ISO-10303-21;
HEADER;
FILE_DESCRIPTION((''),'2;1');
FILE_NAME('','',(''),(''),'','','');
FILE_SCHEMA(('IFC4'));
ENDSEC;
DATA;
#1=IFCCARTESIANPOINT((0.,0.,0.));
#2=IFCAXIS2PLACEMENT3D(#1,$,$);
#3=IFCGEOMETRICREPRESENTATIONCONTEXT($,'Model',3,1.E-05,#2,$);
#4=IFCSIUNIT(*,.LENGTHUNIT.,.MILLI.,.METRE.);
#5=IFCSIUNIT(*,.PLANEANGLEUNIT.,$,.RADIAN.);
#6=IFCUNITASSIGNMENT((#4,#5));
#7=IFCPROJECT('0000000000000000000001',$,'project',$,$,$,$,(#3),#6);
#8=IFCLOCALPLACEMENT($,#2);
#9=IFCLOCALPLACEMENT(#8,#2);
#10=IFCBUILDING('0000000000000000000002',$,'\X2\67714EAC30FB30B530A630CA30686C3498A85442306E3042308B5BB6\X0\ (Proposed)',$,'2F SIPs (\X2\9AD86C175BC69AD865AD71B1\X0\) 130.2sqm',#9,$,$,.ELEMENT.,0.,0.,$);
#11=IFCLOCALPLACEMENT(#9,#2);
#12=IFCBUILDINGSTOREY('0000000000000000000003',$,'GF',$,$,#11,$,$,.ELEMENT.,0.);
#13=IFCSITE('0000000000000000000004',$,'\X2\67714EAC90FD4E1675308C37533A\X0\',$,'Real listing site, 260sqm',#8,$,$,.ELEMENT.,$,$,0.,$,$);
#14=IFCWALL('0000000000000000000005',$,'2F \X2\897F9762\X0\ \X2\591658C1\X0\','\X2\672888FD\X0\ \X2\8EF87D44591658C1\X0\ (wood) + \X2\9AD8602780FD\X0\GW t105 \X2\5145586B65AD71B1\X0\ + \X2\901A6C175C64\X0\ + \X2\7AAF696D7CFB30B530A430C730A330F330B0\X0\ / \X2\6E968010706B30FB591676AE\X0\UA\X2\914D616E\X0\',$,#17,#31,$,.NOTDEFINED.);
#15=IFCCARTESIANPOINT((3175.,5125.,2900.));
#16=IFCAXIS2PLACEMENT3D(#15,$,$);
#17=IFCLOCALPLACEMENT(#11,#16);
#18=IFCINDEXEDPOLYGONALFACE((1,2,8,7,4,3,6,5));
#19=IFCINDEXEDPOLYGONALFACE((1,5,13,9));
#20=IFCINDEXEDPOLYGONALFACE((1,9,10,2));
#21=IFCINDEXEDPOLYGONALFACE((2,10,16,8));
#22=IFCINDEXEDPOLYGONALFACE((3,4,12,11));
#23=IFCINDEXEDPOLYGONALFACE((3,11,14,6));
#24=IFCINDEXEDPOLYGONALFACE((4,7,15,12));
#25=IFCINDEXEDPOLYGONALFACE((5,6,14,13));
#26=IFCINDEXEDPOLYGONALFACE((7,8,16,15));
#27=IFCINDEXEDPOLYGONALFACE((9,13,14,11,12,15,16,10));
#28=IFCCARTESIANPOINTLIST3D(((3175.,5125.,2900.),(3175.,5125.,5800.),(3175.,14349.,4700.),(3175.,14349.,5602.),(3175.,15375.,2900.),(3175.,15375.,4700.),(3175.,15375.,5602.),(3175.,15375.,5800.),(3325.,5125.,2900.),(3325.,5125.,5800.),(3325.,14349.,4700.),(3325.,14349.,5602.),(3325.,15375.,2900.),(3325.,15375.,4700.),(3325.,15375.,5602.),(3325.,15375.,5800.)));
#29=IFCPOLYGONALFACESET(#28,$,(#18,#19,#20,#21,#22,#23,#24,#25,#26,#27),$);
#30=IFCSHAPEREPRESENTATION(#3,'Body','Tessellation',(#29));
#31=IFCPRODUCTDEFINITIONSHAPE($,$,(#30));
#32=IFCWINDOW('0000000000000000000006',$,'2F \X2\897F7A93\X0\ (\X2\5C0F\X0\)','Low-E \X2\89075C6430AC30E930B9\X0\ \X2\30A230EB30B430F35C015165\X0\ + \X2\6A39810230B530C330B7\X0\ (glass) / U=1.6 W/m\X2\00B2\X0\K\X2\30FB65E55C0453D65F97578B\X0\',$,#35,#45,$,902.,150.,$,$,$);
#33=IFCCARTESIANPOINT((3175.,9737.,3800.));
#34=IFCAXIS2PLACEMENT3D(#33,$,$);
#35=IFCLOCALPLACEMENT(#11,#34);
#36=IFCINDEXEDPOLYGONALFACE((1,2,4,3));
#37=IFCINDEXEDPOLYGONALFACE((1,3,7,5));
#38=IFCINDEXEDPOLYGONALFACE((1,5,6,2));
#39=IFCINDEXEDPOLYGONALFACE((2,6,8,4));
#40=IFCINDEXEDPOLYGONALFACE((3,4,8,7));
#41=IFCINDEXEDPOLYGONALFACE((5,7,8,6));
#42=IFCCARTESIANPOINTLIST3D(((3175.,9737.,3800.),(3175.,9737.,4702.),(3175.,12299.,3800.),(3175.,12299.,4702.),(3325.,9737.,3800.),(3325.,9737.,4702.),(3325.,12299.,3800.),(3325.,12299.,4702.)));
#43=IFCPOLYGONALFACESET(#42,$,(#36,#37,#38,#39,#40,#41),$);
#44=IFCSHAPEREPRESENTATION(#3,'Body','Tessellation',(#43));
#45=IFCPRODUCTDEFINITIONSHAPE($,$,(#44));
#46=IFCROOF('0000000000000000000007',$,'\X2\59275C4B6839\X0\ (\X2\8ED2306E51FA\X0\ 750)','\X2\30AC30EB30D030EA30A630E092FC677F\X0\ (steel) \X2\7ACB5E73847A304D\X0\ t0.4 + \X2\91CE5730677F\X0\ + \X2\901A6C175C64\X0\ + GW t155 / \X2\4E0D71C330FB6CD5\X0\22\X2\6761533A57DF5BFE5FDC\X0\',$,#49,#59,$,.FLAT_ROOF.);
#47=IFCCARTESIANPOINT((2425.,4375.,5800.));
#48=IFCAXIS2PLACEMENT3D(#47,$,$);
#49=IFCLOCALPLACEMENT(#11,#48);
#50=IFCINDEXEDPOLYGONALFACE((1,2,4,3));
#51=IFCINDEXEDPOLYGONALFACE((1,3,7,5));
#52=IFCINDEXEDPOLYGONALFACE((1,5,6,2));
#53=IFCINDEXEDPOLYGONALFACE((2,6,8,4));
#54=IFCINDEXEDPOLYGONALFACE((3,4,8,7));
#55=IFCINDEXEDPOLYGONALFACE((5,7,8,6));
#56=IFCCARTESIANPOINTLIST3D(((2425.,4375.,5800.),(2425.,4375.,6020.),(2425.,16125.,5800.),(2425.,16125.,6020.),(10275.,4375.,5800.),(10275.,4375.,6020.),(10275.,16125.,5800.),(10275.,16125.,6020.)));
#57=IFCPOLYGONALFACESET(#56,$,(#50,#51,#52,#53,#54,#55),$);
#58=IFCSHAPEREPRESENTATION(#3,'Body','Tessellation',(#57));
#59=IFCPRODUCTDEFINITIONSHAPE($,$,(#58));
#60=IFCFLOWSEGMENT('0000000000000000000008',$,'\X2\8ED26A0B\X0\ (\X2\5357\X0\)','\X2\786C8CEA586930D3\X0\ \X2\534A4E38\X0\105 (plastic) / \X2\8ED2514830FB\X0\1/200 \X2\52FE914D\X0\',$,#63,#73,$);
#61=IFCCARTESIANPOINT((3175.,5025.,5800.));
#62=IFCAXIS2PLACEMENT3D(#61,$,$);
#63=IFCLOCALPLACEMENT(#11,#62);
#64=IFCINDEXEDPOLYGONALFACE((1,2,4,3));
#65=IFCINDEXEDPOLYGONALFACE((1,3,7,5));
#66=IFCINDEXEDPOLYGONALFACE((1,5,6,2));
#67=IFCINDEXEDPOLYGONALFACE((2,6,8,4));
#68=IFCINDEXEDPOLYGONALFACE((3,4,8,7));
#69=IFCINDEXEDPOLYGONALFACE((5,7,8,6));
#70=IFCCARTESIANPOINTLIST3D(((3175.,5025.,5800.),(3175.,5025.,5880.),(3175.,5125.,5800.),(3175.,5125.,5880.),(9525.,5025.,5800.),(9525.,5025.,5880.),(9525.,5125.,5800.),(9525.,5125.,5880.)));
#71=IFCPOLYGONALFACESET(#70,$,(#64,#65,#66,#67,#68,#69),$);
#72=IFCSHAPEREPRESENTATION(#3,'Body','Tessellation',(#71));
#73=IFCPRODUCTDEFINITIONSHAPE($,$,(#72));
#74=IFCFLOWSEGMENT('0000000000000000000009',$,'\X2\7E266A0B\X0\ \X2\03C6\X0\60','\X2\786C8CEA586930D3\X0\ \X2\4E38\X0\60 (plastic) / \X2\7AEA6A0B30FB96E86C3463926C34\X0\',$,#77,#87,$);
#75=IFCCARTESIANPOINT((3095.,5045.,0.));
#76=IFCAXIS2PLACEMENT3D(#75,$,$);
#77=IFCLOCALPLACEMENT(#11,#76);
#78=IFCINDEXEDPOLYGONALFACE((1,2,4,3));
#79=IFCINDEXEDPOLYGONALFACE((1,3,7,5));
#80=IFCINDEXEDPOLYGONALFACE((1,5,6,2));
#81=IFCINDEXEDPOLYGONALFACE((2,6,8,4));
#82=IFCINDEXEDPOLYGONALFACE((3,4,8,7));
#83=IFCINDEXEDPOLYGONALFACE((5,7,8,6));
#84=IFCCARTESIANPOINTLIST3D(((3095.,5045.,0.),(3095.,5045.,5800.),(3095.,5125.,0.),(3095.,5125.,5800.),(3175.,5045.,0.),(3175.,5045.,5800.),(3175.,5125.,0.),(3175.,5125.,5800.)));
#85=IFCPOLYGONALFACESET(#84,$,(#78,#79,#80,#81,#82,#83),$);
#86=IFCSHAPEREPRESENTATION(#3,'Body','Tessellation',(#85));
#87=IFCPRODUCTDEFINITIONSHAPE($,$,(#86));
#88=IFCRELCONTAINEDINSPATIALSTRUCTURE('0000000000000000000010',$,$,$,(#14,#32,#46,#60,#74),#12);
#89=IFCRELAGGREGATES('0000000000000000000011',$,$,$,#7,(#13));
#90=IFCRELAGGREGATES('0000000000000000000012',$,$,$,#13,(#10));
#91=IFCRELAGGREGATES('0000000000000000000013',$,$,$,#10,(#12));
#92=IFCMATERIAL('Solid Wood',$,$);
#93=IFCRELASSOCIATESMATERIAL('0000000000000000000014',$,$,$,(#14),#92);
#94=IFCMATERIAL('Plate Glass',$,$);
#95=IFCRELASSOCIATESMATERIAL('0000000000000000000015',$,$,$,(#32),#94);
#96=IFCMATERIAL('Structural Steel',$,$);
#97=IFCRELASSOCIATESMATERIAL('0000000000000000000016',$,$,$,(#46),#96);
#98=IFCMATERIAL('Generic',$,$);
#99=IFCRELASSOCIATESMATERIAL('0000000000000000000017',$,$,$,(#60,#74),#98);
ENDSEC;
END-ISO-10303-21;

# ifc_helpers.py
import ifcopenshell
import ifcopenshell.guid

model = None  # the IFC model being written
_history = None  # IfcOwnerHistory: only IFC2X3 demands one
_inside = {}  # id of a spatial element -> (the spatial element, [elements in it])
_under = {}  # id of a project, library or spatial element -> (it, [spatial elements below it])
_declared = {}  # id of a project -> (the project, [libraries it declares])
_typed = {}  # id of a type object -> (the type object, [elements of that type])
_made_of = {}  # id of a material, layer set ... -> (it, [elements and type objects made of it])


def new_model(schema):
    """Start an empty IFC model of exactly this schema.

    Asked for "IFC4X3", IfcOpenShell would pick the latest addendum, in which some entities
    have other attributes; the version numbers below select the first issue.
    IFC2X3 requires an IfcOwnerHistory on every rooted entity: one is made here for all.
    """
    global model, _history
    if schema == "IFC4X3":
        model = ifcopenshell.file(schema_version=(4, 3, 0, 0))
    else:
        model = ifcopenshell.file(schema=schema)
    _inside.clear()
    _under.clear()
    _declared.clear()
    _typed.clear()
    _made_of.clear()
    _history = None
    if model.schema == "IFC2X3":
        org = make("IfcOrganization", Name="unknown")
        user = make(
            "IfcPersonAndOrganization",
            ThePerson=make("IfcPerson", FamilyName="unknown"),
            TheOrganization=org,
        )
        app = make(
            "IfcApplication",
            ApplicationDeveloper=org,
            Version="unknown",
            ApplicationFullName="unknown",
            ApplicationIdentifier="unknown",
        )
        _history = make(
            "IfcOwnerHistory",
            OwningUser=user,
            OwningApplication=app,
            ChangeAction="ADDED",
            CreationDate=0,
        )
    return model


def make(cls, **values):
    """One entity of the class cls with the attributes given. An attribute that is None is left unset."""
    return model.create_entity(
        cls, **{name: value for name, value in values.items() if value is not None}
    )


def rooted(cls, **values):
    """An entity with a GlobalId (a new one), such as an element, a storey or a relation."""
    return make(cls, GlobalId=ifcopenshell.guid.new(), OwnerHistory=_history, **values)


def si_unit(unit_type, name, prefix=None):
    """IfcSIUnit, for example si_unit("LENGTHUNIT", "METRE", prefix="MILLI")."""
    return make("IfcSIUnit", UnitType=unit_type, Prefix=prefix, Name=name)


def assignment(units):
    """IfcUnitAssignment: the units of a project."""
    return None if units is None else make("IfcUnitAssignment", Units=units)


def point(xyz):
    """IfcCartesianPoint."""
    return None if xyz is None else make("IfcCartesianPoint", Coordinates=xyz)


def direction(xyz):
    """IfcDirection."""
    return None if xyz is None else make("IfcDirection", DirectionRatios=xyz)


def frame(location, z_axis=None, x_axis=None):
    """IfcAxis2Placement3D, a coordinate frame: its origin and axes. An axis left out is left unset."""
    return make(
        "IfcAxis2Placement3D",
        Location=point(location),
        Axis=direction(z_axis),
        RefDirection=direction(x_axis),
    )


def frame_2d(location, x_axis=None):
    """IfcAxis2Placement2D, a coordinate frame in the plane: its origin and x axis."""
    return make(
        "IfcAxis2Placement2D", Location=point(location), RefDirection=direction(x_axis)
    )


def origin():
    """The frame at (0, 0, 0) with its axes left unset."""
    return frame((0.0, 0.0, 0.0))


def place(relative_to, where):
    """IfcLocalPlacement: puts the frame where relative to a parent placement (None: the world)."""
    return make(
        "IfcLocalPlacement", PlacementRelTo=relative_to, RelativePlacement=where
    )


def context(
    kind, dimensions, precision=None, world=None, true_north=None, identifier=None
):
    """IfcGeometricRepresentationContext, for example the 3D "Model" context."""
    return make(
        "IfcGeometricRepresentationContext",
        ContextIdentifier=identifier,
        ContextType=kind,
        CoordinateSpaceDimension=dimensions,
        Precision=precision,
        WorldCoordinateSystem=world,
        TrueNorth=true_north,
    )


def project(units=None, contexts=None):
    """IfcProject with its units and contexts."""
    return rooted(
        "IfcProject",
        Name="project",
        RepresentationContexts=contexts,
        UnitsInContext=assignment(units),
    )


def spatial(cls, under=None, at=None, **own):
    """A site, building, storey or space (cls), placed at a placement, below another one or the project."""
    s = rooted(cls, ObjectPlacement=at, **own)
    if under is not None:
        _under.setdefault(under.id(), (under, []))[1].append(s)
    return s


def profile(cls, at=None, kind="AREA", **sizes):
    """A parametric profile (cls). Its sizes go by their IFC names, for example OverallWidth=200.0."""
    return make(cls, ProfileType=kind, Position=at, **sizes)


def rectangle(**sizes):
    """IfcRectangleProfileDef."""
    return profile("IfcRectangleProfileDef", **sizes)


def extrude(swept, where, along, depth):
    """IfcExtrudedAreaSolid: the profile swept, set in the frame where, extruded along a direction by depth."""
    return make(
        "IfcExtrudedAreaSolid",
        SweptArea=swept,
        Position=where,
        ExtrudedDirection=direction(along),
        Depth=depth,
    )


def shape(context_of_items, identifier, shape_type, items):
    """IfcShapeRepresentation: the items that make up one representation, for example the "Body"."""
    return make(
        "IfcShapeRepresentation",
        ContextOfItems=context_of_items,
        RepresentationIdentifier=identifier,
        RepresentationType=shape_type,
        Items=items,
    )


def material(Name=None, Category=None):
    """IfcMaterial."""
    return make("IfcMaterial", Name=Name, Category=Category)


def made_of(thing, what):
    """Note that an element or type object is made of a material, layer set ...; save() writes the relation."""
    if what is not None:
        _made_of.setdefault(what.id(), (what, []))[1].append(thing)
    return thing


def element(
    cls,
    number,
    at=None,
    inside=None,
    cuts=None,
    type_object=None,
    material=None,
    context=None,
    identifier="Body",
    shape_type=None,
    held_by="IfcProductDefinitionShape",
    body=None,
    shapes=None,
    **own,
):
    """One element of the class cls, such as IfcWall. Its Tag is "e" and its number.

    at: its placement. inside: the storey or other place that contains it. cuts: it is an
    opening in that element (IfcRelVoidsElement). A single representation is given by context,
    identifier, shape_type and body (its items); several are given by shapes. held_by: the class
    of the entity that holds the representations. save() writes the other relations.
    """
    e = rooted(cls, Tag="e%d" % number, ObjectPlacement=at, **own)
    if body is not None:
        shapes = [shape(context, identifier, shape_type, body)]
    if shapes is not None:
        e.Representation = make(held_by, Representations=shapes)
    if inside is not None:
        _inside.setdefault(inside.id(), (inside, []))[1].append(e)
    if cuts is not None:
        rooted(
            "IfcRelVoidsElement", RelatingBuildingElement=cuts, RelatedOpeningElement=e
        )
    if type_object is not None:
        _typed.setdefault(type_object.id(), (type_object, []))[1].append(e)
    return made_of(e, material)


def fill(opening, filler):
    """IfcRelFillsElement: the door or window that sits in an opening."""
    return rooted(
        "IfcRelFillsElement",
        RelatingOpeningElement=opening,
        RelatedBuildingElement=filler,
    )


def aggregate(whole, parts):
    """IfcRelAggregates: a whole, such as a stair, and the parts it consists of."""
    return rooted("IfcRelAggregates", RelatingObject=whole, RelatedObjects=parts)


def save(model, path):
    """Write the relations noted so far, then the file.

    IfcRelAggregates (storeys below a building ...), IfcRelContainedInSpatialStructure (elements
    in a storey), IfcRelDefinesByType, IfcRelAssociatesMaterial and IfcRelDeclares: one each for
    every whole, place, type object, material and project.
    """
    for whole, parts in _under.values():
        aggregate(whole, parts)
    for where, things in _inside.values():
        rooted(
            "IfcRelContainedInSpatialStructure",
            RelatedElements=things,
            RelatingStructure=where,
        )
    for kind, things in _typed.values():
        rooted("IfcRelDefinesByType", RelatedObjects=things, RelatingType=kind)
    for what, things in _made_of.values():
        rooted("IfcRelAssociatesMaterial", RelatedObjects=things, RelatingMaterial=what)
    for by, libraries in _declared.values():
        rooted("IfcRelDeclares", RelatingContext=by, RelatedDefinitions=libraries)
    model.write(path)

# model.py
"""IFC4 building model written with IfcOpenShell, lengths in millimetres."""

from ifc_helpers import new_model, si_unit, frame, frame_2d, origin, place, context, project, spatial, rectangle, extrude, material, element, fill, save


model = new_model("IFC4")

# Units and contexts
model_context = context("Model", 3, precision=1e-05, world=origin())
ifc_project = project(units=[si_unit("LENGTHUNIT", "METRE", prefix="MILLI"), si_unit("PLANEANGLEUNIT", "RADIAN")], contexts=[model_context])

# Site, building, storey
site_placement = place(None, origin())
site = spatial("IfcSite", under=ifc_project, at=site_placement, Name="東京都世田谷区", ObjectType="Real listing site, 260sqm", CompositionType="ELEMENT", RefElevation=0.0)
building_placement = place(site_placement, origin())
building = spatial("IfcBuilding", under=site, at=building_placement, Name="東京・サウナと水風呂のある家 (Proposed)", ObjectType="2F SIPs (高気密高断熱) 130.2sqm", CompositionType="ELEMENT", ElevationOfRefHeight=0.0, ElevationOfTerrain=0.0)
storey_placement = place(building_placement, origin())
storey = spatial("IfcBuildingStorey", under=building, at=storey_placement, Name="GF", CompositionType="ELEMENT", Elevation=0.0)

# Shared definitions
ifc_material_1 = material(Name="Solid Wood")

# Shared definitions
ifc_material_2 = material(Name="Plate Glass")

# Wall, opening, window
wall_1_placement = place(storey_placement, frame((3175.0, 5125.0, 2900.0)))
wall_1 = element("IfcWall", 1, at=wall_1_placement, inside=storey, material=ifc_material_1, Name="2F 西面 外壁", Description="木製 軸組外壁 (wood) + 高性能GW t105 充填断熱 + 通気層 + 窯業系サイディング / 準耐火・外皮UA配慮", PredefinedType="NOTDEFINED", context=model_context, shape_type="SweptSolid", body=[
    extrude(rectangle(XDim=150.0, YDim=10250.0, at=frame_2d((75.0, 5125.0))), frame((3175.0, 5125.0, 2900.0)), (0.0, 0.0, 1.0), 2900.0),
])
opening_1_placement = place(storey_placement, frame((3175.0, 9737.0, 3800.0)))
opening_1 = element("IfcOpeningElement", 2, at=opening_1_placement, cuts=wall_1, PredefinedType="NOTDEFINED", context=model_context, shape_type="SweptSolid", body=[
    extrude(rectangle(XDim=150.0, YDim=2562.0, at=frame_2d((75.0, 1281.0))), frame((3175.0, 9737.0, 3800.0)), (0.0, 0.0, 1.0), 902.0),
])
window_1_placement = place(storey_placement, frame((3175.0, 9737.0, 3800.0)))
window_1 = element("IfcWindow", 3, at=window_1_placement, inside=storey, material=ifc_material_2, Name="2F 西窓 (小)", Description="Low-E 複層ガラス アルゴン封入 + 樹脂サッシ (glass) / U=1.6 W/m²K・日射取得型", OverallHeight=902.0, OverallWidth=150.0, context=model_context, shape_type="SweptSolid", body=[
    extrude(rectangle(XDim=150.0, YDim=2562.0, at=frame_2d((75.0, 1281.0))), frame((3175.0, 9737.0, 3800.0)), (0.0, 0.0, 1.0), 902.0),
])
fill(opening_1, window_1)

# Roof
ifc_material_3 = material(Name="Structural Steel")
roof_placement = place(storey_placement, frame((2425.0, 4375.0, 5800.0)))
element("IfcRoof", 4, at=roof_placement, inside=storey, material=ifc_material_3, Name="大屋根 (軒の出 750)", Description="ガルバリウム鋼板 (steel) 立平葺き t0.4 + 野地板 + 通気層 + GW t155 / 不燃・法22条区域対応", PredefinedType="FLAT_ROOF", context=model_context, shape_type="SweptSolid", body=[
    extrude(rectangle(XDim=7850.0, YDim=11750.0, at=frame_2d((3925.0, 5875.0))), frame((2425.0, 4375.0, 5800.0)), (0.0, 0.0, 1.0), 220.0),
])

# Flow segments
ifc_material_4 = material(Name="Generic")
flow_segment_1_placement = place(storey_placement, frame((3175.0, 5025.0, 5800.0)))
element("IfcFlowSegment", 5, at=flow_segment_1_placement, inside=storey, material=ifc_material_4, Name="軒樋 (南)", Description="硬質塩ビ 半丸105 (plastic) / 軒先・1/200 勾配", context=model_context, shape_type="SweptSolid", body=[
    extrude(rectangle(XDim=6350.0, YDim=100.0, at=frame_2d((3175.0, 50.0))), frame((3175.0, 5025.0, 5800.0)), (0.0, 0.0, 1.0), 80.0),
])
flow_segment_2_placement = place(storey_placement, frame((3095.0, 5045.0, 0.0)))
element("IfcFlowSegment", 6, at=flow_segment_2_placement, inside=storey, material=ifc_material_4, Name="縦樋 φ60", Description="硬質塩ビ 丸60 (plastic) / 竪樋・雨水排水", context=model_context, shape_type="SweptSolid", body=[
    extrude(rectangle(XDim=80.0, YDim=80.0, at=frame_2d((40.0, 40.0))), frame((3095.0, 5045.0, 0.0)), (0.0, 0.0, 1.0), 5800.0),
])

save(model, "model.ifc")
